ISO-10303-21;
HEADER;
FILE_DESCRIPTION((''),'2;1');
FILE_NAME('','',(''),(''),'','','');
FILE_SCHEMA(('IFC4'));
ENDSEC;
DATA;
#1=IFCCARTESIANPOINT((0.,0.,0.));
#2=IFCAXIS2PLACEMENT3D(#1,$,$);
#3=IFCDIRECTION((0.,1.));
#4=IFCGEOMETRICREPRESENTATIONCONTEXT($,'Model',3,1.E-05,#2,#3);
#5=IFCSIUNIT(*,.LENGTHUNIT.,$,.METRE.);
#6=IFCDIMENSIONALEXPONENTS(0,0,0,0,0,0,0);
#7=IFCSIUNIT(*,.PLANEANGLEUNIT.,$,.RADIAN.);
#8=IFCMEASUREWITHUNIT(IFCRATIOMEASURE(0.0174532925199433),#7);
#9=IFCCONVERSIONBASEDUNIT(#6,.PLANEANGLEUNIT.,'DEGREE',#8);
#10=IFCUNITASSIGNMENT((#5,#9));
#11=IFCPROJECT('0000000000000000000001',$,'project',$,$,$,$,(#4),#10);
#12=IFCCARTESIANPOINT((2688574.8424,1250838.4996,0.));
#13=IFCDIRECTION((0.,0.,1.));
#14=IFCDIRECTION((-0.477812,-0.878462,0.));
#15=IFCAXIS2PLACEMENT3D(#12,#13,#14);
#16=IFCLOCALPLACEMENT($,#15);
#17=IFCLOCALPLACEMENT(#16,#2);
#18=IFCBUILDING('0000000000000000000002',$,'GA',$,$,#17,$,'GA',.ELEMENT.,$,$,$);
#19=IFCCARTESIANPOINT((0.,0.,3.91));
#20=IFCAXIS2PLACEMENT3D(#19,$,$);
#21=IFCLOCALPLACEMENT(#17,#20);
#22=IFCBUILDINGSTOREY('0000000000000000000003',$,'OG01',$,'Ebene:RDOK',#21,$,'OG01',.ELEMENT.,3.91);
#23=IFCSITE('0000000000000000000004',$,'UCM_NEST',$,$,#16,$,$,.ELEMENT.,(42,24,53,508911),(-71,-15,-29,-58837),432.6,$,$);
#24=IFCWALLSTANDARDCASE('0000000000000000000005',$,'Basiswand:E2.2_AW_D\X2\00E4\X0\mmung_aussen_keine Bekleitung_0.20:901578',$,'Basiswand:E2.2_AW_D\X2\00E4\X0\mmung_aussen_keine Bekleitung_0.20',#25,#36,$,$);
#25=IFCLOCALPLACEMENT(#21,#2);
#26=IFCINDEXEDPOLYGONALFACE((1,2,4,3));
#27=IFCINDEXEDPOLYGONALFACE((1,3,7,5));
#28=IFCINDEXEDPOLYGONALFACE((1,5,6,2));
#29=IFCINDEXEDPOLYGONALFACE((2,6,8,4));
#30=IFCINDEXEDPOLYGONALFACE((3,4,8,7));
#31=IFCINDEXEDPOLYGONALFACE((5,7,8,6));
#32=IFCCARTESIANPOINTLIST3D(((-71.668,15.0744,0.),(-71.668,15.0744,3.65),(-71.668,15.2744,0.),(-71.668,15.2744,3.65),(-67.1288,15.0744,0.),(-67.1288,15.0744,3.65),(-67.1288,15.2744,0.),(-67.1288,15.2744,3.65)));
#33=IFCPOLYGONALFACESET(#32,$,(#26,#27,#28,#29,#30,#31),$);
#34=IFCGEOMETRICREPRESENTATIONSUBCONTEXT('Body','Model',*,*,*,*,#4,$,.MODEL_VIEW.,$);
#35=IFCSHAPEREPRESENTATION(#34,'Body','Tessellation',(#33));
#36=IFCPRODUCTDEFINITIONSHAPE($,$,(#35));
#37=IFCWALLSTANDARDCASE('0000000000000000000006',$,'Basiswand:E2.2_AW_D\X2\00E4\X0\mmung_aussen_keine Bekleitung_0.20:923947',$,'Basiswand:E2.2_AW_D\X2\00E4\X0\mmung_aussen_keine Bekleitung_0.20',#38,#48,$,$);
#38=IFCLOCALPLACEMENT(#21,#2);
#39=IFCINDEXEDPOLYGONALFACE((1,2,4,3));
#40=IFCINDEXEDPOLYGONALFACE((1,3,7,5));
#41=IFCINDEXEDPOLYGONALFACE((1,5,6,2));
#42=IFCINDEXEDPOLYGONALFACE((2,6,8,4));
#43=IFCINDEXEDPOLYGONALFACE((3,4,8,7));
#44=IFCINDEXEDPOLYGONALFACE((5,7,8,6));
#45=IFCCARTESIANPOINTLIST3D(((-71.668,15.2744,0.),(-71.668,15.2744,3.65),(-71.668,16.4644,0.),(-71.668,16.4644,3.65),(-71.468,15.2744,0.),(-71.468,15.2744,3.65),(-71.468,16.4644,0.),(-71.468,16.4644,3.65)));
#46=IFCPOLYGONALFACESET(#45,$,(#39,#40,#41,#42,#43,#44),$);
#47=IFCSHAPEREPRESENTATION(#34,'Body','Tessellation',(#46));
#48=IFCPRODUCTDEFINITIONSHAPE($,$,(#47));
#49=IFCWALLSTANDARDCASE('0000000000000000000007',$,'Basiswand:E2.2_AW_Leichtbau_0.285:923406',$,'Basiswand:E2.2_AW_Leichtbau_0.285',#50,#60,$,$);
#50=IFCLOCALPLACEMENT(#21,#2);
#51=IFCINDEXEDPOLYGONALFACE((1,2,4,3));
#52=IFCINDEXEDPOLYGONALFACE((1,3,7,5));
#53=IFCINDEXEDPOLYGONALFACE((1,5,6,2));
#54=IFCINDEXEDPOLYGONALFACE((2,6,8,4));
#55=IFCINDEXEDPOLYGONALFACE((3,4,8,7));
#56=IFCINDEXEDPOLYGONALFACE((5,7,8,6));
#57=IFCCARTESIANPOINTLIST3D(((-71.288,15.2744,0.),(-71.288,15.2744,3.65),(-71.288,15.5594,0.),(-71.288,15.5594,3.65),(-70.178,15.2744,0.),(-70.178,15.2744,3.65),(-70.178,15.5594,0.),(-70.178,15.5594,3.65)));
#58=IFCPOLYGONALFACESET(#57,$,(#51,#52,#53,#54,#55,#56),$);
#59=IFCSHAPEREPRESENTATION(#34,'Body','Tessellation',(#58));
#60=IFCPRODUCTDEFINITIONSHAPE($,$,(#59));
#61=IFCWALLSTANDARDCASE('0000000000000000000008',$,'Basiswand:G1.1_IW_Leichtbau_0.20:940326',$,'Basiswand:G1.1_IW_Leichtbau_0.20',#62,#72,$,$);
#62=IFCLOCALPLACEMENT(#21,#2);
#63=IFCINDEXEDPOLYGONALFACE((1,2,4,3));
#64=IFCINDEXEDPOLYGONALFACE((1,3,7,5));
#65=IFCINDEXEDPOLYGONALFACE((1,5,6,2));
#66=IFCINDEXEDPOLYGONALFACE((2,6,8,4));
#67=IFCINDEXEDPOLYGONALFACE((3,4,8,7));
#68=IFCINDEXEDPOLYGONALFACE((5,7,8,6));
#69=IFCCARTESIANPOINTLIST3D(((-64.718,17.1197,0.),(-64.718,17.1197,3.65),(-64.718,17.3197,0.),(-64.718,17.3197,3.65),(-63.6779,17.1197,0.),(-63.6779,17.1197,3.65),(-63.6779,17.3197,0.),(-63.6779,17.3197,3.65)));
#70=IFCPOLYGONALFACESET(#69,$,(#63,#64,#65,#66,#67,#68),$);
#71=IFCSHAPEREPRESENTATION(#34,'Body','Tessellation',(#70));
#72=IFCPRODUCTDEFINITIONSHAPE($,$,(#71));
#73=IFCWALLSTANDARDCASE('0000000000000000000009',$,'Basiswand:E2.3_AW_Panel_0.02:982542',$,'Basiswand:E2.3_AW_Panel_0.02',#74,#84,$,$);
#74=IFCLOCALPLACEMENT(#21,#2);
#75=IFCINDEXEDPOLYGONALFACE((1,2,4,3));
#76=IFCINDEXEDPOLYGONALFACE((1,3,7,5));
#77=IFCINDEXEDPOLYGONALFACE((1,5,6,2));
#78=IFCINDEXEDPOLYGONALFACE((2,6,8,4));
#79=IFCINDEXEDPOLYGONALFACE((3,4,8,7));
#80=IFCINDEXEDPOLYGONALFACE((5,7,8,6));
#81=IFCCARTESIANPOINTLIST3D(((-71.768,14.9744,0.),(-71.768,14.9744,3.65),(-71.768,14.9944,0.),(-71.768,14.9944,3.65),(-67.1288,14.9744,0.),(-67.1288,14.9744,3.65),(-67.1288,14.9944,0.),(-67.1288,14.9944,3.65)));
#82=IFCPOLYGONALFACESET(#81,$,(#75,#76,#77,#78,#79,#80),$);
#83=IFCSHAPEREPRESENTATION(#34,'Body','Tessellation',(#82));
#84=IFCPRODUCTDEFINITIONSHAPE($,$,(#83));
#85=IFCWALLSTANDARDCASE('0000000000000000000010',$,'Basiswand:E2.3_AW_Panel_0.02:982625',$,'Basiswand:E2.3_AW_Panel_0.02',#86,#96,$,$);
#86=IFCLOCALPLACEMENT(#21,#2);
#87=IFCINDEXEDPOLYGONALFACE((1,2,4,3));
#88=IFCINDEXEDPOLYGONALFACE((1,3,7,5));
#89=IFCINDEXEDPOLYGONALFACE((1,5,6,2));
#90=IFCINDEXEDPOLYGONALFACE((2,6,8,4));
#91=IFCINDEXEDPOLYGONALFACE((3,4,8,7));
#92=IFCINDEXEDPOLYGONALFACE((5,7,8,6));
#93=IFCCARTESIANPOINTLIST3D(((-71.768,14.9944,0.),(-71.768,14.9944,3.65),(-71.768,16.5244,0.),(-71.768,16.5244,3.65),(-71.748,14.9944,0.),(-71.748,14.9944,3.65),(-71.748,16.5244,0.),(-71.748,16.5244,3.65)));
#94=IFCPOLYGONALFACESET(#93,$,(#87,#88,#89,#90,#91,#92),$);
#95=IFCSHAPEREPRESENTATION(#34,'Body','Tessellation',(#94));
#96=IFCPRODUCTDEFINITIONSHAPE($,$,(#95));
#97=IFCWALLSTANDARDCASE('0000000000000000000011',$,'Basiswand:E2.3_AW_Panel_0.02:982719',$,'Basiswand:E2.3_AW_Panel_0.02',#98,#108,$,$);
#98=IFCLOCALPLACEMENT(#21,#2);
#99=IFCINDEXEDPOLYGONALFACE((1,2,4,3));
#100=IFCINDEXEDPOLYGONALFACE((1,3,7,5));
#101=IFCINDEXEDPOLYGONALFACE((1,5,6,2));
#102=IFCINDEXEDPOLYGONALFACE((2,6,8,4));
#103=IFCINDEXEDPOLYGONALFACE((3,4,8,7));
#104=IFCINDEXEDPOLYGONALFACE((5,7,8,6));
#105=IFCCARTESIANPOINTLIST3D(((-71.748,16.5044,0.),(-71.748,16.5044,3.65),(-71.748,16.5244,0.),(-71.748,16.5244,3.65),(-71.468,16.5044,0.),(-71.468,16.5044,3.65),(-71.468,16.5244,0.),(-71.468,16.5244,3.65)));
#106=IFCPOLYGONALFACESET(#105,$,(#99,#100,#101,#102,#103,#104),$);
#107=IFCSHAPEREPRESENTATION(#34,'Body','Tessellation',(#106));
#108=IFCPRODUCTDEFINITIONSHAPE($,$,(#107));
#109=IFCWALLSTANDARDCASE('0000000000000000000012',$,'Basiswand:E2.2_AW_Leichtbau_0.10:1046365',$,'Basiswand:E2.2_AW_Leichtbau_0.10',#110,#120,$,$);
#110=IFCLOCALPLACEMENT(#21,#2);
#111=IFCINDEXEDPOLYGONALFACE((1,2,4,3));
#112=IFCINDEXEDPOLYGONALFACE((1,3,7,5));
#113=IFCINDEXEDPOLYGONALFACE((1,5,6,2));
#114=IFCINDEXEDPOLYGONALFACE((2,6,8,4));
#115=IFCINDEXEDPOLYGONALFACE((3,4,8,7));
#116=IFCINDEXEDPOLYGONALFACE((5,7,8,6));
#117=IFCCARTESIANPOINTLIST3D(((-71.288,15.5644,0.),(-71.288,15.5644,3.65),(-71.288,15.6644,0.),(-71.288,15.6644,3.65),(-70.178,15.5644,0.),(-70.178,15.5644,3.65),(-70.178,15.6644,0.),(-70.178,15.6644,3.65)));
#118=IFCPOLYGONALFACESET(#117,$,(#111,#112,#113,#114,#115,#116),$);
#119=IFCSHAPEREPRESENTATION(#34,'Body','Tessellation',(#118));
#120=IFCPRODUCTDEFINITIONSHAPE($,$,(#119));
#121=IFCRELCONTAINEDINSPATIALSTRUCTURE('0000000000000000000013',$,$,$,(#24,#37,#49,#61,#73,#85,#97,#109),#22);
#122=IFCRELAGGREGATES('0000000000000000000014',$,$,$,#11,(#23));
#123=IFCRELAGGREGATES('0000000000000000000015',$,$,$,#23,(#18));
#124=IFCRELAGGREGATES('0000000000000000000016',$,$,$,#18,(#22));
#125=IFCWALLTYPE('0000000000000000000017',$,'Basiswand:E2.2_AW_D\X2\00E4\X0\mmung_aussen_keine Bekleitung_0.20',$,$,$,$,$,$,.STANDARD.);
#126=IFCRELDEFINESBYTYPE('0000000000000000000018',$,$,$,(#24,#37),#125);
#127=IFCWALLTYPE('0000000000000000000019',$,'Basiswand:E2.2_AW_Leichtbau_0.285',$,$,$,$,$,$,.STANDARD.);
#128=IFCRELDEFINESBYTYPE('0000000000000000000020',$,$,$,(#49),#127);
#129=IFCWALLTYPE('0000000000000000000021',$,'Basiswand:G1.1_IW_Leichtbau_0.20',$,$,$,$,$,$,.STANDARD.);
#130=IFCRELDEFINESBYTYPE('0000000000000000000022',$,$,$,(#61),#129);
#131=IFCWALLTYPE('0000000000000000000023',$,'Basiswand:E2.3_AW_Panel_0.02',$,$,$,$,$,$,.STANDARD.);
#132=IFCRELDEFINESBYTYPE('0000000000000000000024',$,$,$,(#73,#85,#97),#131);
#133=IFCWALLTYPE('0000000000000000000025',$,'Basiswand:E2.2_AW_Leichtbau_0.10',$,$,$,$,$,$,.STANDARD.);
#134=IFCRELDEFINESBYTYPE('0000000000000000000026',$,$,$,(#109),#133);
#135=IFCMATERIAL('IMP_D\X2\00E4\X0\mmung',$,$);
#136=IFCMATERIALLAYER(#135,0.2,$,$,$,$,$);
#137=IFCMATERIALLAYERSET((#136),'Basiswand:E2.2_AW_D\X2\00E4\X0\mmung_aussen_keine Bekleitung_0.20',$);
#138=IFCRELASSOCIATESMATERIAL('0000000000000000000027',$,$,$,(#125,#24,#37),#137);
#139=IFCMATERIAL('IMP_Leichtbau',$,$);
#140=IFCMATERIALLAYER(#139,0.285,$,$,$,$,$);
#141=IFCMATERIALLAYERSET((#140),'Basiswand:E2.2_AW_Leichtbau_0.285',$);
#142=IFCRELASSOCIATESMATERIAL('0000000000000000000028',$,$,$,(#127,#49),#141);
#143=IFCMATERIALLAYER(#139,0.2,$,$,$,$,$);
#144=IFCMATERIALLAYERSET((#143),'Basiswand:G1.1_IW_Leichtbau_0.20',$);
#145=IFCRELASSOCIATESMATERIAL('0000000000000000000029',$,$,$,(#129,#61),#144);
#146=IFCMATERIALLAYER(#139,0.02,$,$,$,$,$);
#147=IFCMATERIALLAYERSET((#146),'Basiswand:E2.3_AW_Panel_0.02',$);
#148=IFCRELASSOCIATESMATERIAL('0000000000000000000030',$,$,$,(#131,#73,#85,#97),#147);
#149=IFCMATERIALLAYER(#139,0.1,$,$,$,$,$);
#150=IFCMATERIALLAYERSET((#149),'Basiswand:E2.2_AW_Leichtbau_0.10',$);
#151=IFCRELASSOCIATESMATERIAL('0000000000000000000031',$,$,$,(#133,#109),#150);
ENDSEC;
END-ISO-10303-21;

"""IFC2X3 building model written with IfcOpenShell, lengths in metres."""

from ifc_helpers import new_model, entity, si_unit, converted_unit, direction, frame, frame_2d, origin, place, context, subcontext, project, spatial, rectangle, extrude, material, layer, layer_set, layer_usage, type_object, element, save


model = new_model("IFC2X3")

# Units and contexts
model_context = context("Model", 3, precision=1e-05, world=origin(), true_north=direction((0.0, 1.0)))
body_context = subcontext(model_context, "Body", "Model", "MODEL_VIEW")
ifc_project = project(units=[si_unit("LENGTHUNIT", "METRE"), converted_unit("PLANEANGLEUNIT", "DEGREE", entity("IfcRatioMeasure", 0.0174532925199433), si_unit("PLANEANGLEUNIT", "RADIAN"), dimensions=[0, 0, 0, 0, 0, 0, 0])], contexts=[model_context])

# Site, building, storey
site_placement = place(None, frame((2688574.8424, 1250838.4996, 0.0), z_axis=(0.0, 0.0, 1.0), x_axis=(-0.477812, -0.878462, 0.0)))
site = spatial("IfcSite", under=ifc_project, at=site_placement, Name="UCM_NEST", CompositionType="ELEMENT", RefLatitude=(42, 24, 53, 508911), RefLongitude=(-71, -15, -29, -58837), RefElevation=432.6)
building_placement = place(site_placement, origin())
building = spatial("IfcBuilding", under=site, at=building_placement, Name="GA", LongName="GA", CompositionType="ELEMENT")
storey_placement = place(building_placement, frame((0.0, 0.0, 3.91)))
storey = spatial("IfcBuildingStorey", under=building, at=storey_placement, Name="OG01", ObjectType="Ebene:RDOK", LongName="OG01", CompositionType="ELEMENT", Elevation=3.91)

# Walls
ifc_material_1 = material(Name="IMP_Dämmung")
ifc_layer_1 = layer(ifc_material_1, 0.2)
ifc_layer_set_1 = layer_set([ifc_layer_1], Name="Basiswand:E2.2_AW_Dämmung_aussen_keine Bekleitung_0.20")
ifc_layer_usage_1 = layer_usage(ifc_layer_set_1, "AXIS2", "NEGATIVE", 0.1)
wall_type_1 = type_object("IfcWallType", Name="Basiswand:E2.2_AW_Dämmung_aussen_keine Bekleitung_0.20", PredefinedType="STANDARD", material=ifc_layer_set_1)
wall_1_placement = place(storey_placement, frame((-67.1288, 15.1744, 0.0), z_axis=(0.0, 0.0, 1.0), x_axis=(-1.0, 0.0, 0.0)))
element("IfcWallStandardCase", 1, at=wall_1_placement, inside=storey, type_object=wall_type_1, material=ifc_layer_usage_1, Name="Basiswand:E2.2_AW_Dämmung_aussen_keine Bekleitung_0.20:901578", ObjectType="Basiswand:E2.2_AW_Dämmung_aussen_keine Bekleitung_0.20", context=body_context, shape_type="SweptSolid", body=[
    extrude(rectangle(XDim=4.5392, YDim=0.2, at=frame_2d((2.2696, 0.0), x_axis=(-1.0, 0.0))), origin(), (0.0, 0.0, 1.0), 3.65),
])
ifc_layer_usage_2 = layer_usage(ifc_layer_set_1, "AXIS2", "NEGATIVE", 0.1)
wall_2_placement = place(storey_placement, frame((-71.568, 15.2744, 0.0), z_axis=(0.0, 0.0, 1.0), x_axis=(0.0, 1.0, 0.0)))
element("IfcWallStandardCase", 2, at=wall_2_placement, inside=storey, type_object=wall_type_1, material=ifc_layer_usage_2, Name="Basiswand:E2.2_AW_Dämmung_aussen_keine Bekleitung_0.20:923947", ObjectType="Basiswand:E2.2_AW_Dämmung_aussen_keine Bekleitung_0.20", context=body_context, shape_type="SweptSolid", body=[
    extrude(rectangle(XDim=1.19, YDim=0.2, at=frame_2d((0.595, 0.0), x_axis=(-1.0, 0.0))), origin(), (0.0, 0.0, 1.0), 3.65),
])

# Wall
ifc_material_2 = material(Name="IMP_Leichtbau")
ifc_layer_2 = layer(ifc_material_2, 0.285)
ifc_layer_set_2 = layer_set([ifc_layer_2], Name="Basiswand:E2.2_AW_Leichtbau_0.285")
ifc_layer_usage_3 = layer_usage(ifc_layer_set_2, "AXIS2", "NEGATIVE", 0.1425)
wall_type_2 = type_object("IfcWallType", Name="Basiswand:E2.2_AW_Leichtbau_0.285", PredefinedType="STANDARD", material=ifc_layer_set_2)
wall_3_placement = place(storey_placement, frame((-70.178, 15.4169, 0.0), z_axis=(0.0, 0.0, 1.0), x_axis=(-1.0, 0.0, 0.0)))
element("IfcWallStandardCase", 3, at=wall_3_placement, inside=storey, type_object=wall_type_2, material=ifc_layer_usage_3, Name="Basiswand:E2.2_AW_Leichtbau_0.285:923406", ObjectType="Basiswand:E2.2_AW_Leichtbau_0.285", context=body_context, shape_type="SweptSolid", body=[
    extrude(rectangle(XDim=1.11, YDim=0.285, at=frame_2d((0.555, 0.0), x_axis=(-1.0, 0.0))), origin(), (0.0, 0.0, 1.0), 3.65),
])

# Walls
ifc_layer_3 = layer(ifc_material_2, 0.2)
ifc_layer_set_3 = layer_set([ifc_layer_3], Name="Basiswand:G1.1_IW_Leichtbau_0.20")
ifc_layer_usage_4 = layer_usage(ifc_layer_set_3, "AXIS2", "NEGATIVE", 0.1)
wall_type_3 = type_object("IfcWallType", Name="Basiswand:G1.1_IW_Leichtbau_0.20", PredefinedType="STANDARD", material=ifc_layer_set_3)
wall_4_placement = place(storey_placement, frame((-64.718, 17.2197, 0.0)))
element("IfcWallStandardCase", 4, at=wall_4_placement, inside=storey, type_object=wall_type_3, material=ifc_layer_usage_4, Name="Basiswand:G1.1_IW_Leichtbau_0.20:940326", ObjectType="Basiswand:G1.1_IW_Leichtbau_0.20", context=body_context, shape_type="SweptSolid", body=[
    extrude(rectangle(XDim=1.0401, YDim=0.2, at=frame_2d((0.52, 0.0), x_axis=(-1.0, 0.0))), origin(), (0.0, 0.0, 1.0), 3.65),
])
ifc_layer_4 = layer(ifc_material_2, 0.02)
ifc_layer_set_4 = layer_set([ifc_layer_4], Name="Basiswand:E2.3_AW_Panel_0.02")
ifc_layer_usage_5 = layer_usage(ifc_layer_set_4, "AXIS2", "NEGATIVE", 0.01)
wall_type_4 = type_object("IfcWallType", Name="Basiswand:E2.3_AW_Panel_0.02", PredefinedType="STANDARD", material=ifc_layer_set_4)
wall_5_placement = place(storey_placement, frame((-67.1288, 14.9844, 0.0), z_axis=(0.0, 0.0, 1.0), x_axis=(-1.0, 0.0, 0.0)))
element("IfcWallStandardCase", 5, at=wall_5_placement, inside=storey, type_object=wall_type_4, material=ifc_layer_usage_5, Name="Basiswand:E2.3_AW_Panel_0.02:982542", ObjectType="Basiswand:E2.3_AW_Panel_0.02", context=body_context, shape_type="SweptSolid", body=[
    extrude(rectangle(XDim=4.6392, YDim=0.02, at=frame_2d((2.3196, 0.0), x_axis=(-1.0, 0.0))), origin(), (0.0, 0.0, 1.0), 3.65),
])
ifc_layer_usage_6 = layer_usage(ifc_layer_set_4, "AXIS2", "NEGATIVE", 0.01)
wall_6_placement = place(storey_placement, frame((-71.758, 14.9944, 0.0), z_axis=(0.0, 0.0, 1.0), x_axis=(0.0, 1.0, 0.0)))
element("IfcWallStandardCase", 6, at=wall_6_placement, inside=storey, type_object=wall_type_4, material=ifc_layer_usage_6, Name="Basiswand:E2.3_AW_Panel_0.02:982625", ObjectType="Basiswand:E2.3_AW_Panel_0.02", context=body_context, shape_type="SweptSolid", body=[
    extrude(rectangle(XDim=1.53, YDim=0.02, at=frame_2d((0.765, 0.0), x_axis=(-1.0, 0.0))), origin(), (0.0, 0.0, 1.0), 3.65),
])
ifc_layer_usage_7 = layer_usage(ifc_layer_set_4, "AXIS2", "NEGATIVE", 0.01)
wall_7_placement = place(storey_placement, frame((-71.748, 16.5144, 0.0)))
element("IfcWallStandardCase", 7, at=wall_7_placement, inside=storey, type_object=wall_type_4, material=ifc_layer_usage_7, Name="Basiswand:E2.3_AW_Panel_0.02:982719", ObjectType="Basiswand:E2.3_AW_Panel_0.02", context=body_context, shape_type="SweptSolid", body=[
    extrude(rectangle(XDim=0.28, YDim=0.02, at=frame_2d((0.14, 0.0), x_axis=(-1.0, 0.0))), origin(), (0.0, 0.0, 1.0), 3.65),
])
ifc_layer_5 = layer(ifc_material_2, 0.1)
ifc_layer_set_5 = layer_set([ifc_layer_5], Name="Basiswand:E2.2_AW_Leichtbau_0.10")
ifc_layer_usage_8 = layer_usage(ifc_layer_set_5, "AXIS2", "NEGATIVE", 0.05)
wall_type_5 = type_object("IfcWallType", Name="Basiswand:E2.2_AW_Leichtbau_0.10", PredefinedType="STANDARD", material=ifc_layer_set_5)
wall_8_placement = place(storey_placement, frame((-71.288, 15.6144, 0.0)))
element("IfcWallStandardCase", 8, at=wall_8_placement, inside=storey, type_object=wall_type_5, material=ifc_layer_usage_8, Name="Basiswand:E2.2_AW_Leichtbau_0.10:1046365", ObjectType="Basiswand:E2.2_AW_Leichtbau_0.10", context=body_context, shape_type="SweptSolid", body=[
    extrude(rectangle(XDim=1.11, YDim=0.1, at=frame_2d((0.555, 0.0), x_axis=(-1.0, 0.0))), origin(), (0.0, 0.0, 1.0), 3.65),
])

save(model, "model.ifc")
